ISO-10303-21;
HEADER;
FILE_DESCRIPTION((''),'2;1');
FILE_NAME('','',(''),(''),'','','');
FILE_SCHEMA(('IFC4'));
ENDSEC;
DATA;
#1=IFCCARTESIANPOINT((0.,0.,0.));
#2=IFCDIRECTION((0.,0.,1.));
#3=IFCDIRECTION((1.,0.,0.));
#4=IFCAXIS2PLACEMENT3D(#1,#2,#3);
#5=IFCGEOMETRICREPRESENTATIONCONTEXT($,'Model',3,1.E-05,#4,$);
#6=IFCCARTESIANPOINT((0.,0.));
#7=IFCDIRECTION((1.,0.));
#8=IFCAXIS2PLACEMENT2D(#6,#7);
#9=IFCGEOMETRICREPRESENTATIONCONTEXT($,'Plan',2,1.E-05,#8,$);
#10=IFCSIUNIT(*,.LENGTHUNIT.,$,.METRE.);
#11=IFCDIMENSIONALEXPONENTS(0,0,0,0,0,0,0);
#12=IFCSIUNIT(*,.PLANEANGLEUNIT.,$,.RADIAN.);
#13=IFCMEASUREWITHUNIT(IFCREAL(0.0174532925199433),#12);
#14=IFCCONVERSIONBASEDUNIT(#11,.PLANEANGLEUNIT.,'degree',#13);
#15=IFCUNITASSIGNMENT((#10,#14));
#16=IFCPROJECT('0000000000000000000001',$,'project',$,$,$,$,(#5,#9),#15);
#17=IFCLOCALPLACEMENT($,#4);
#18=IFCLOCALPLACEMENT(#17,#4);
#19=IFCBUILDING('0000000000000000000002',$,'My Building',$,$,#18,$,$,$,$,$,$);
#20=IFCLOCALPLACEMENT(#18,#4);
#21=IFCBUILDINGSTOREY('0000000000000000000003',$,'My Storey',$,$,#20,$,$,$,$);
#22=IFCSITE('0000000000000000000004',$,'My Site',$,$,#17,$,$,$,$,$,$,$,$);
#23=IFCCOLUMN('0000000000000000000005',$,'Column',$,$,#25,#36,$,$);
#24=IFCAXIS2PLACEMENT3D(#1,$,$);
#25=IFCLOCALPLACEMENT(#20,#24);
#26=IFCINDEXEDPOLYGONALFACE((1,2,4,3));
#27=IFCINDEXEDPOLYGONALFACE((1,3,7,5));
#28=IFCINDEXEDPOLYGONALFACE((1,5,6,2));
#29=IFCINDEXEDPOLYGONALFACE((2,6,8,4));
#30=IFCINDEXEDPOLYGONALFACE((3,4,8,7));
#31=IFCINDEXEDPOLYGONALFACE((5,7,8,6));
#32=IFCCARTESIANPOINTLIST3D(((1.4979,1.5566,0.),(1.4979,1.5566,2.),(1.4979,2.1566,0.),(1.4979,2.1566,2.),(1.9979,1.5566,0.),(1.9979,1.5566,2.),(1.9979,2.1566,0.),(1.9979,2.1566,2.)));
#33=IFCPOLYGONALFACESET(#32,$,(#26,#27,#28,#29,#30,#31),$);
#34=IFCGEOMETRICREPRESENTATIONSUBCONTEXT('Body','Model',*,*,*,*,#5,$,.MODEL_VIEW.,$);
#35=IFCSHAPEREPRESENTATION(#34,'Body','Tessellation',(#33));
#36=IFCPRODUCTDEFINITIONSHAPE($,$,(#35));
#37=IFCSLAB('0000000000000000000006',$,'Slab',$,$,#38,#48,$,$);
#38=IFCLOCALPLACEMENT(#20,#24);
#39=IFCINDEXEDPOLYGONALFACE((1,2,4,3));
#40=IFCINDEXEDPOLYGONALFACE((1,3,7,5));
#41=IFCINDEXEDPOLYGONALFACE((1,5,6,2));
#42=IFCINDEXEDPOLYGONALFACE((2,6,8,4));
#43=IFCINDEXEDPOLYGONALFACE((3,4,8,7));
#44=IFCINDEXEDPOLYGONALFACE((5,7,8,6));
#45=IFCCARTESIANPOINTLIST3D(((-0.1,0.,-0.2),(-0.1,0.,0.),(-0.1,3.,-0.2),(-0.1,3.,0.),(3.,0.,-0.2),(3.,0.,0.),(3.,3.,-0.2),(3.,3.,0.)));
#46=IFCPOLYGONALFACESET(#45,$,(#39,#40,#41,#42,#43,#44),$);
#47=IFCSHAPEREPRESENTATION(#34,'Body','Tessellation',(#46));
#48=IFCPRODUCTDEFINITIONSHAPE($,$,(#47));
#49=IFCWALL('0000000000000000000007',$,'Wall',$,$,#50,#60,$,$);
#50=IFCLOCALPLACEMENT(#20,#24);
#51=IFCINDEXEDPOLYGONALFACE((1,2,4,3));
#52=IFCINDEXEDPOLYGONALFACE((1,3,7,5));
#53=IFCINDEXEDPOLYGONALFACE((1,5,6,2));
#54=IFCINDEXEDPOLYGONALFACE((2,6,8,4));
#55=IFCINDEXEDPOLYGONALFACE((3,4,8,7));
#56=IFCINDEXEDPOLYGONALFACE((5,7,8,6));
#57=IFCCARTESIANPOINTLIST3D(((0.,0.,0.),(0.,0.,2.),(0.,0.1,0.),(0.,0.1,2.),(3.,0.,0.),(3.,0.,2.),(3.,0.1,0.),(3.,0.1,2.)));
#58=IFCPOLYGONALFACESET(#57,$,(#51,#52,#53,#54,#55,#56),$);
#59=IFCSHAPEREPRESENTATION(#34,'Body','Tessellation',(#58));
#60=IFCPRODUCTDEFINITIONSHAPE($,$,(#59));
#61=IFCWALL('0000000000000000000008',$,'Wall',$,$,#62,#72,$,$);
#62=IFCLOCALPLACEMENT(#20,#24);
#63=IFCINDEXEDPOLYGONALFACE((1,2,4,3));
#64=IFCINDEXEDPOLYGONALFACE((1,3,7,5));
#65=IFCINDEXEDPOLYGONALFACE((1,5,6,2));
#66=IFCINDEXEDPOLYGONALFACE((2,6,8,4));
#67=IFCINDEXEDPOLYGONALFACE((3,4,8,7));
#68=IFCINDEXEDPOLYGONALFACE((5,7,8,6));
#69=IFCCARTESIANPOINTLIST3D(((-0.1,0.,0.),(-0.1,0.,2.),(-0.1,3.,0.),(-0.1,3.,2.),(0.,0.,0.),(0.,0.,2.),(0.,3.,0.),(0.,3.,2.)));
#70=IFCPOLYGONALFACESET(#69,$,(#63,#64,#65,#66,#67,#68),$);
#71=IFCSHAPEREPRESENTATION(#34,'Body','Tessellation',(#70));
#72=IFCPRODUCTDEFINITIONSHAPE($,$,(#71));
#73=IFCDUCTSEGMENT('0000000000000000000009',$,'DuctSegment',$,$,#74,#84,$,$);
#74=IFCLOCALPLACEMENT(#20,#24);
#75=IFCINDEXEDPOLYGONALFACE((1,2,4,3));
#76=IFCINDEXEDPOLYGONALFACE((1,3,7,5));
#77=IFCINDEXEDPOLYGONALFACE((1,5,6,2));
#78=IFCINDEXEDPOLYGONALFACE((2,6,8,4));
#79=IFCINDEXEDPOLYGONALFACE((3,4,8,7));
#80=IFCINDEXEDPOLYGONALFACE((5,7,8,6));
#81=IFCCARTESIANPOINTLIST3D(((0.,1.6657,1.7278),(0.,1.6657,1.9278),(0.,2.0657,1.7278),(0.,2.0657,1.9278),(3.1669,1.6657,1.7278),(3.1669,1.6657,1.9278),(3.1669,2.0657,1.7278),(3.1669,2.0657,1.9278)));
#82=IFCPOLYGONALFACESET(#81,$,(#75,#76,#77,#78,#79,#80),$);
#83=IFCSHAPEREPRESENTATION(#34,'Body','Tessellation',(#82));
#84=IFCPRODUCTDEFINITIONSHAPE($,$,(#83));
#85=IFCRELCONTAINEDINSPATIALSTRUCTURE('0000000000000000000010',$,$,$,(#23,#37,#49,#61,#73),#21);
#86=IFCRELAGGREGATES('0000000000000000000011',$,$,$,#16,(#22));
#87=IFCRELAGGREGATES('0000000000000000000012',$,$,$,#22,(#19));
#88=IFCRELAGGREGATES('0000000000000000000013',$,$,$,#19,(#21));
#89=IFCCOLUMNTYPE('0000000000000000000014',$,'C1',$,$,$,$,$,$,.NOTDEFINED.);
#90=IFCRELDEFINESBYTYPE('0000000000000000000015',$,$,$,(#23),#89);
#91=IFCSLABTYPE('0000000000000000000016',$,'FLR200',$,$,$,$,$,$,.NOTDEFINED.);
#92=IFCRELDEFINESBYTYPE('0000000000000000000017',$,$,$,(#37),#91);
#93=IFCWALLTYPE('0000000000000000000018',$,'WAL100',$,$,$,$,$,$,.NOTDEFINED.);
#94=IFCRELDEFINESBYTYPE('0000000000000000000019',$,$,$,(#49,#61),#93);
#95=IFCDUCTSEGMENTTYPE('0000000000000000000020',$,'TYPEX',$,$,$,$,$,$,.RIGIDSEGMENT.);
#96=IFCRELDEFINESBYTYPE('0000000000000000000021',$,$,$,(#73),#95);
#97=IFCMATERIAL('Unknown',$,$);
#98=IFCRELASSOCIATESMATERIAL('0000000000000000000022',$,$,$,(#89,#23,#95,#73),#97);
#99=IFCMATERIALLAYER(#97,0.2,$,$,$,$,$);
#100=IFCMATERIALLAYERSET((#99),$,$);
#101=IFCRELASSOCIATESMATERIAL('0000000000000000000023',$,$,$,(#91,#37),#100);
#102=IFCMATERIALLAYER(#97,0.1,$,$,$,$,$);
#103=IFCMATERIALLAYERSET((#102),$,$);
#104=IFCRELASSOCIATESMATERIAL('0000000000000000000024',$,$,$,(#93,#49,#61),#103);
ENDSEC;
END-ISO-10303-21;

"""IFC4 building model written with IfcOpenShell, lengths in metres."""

from ifc_helpers import new_model, entity, si_unit, converted_unit, frame, origin_with_axes, origin_2d_with_axis, place, context, subcontext, project, spatial, line, indexed_curve, rectangle, outline, extrude, material, layer, layer_set, layer_usage, material_profile, profile_set, profile_usage, type_object, element, save


model = new_model("IFC4")

# Units and contexts
model_context = context("Model", 3, precision=1e-05, world=origin_with_axes())
plan_context = context("Plan", 2, precision=1e-05, world=origin_2d_with_axis())
body_context = subcontext(model_context, "Body", "Model", "MODEL_VIEW")
ifc_project = project(units=[si_unit("LENGTHUNIT", "METRE"), converted_unit("PLANEANGLEUNIT", "degree", entity("IfcReal", 0.0174532925199433), si_unit("PLANEANGLEUNIT", "RADIAN"), dimensions=[0, 0, 0, 0, 0, 0, 0])], contexts=[model_context, plan_context])

# Site, building, storey
site_placement = place(None, origin_with_axes())
site = spatial("IfcSite", under=ifc_project, at=site_placement, Name="My Site")
building_placement = place(site_placement, origin_with_axes())
building = spatial("IfcBuilding", under=site, at=building_placement, Name="My Building")
storey_placement = place(building_placement, origin_with_axes())
storey = spatial("IfcBuildingStorey", under=building, at=storey_placement, Name="My Storey")

# Column
ifc_material = material(Name="Unknown")
ifc_material_profile_1 = material_profile(ifc_material, rectangle(XDim=0.5, YDim=0.6))
ifc_profile_set_1 = profile_set([ifc_material_profile_1])
ifc_profile_usage_1 = profile_usage(ifc_profile_set_1, cardinal=5)
column_type = type_object("IfcColumnType", Name="C1", PredefinedType="NOTDEFINED", material=ifc_profile_set_1)
column_placement = place(storey_placement, frame((1.7479, 1.8566, 0.0), z_axis=(0.0, 0.0, 1.0), x_axis=(1.0, 0.0, 0.0)))
element("IfcColumn", 1, at=column_placement, inside=storey, type_object=column_type, material=ifc_profile_usage_1, Name="Column", context=body_context, shape_type="SweptSolid", body=[
    extrude(rectangle(XDim=0.5, YDim=0.6), origin_with_axes(), (0.0, 0.0, 1.0), 2.0),
])

# Slab
ifc_layer_1 = layer(ifc_material, 0.2)
ifc_layer_set_1 = layer_set([ifc_layer_1])
ifc_layer_usage_1 = layer_usage(ifc_layer_set_1, "AXIS3", "POSITIVE", 0.0)
slab_type = type_object("IfcSlabType", Name="FLR200", PredefinedType="NOTDEFINED", material=ifc_layer_set_1)
slab_placement = place(storey_placement, frame((0.0, 0.0, -0.2), z_axis=(0.0, 0.0, 1.0), x_axis=(1.0, 0.0, 0.0)))
element("IfcSlab", 2, at=slab_placement, inside=storey, type_object=slab_type, material=ifc_layer_usage_1, Name="Slab", context=body_context, shape_type="SweptSolid", body=[
    extrude(outline(indexed_curve([(-0.1, 3.0), (-0.1, 0.0), (3.0, 0.0), (3.0, 3.0)], segments=[line(4, 1), line(1, 2), line(2, 3), line(3, 4)], self_intersect=False)), None, (0.0, 0.0, 1.0), 0.2),
])

# Walls
ifc_layer_2 = layer(ifc_material, 0.1)
ifc_layer_set_2 = layer_set([ifc_layer_2])
ifc_layer_usage_2 = layer_usage(ifc_layer_set_2, "AXIS2", "POSITIVE", 0.0)
wall_type = type_object("IfcWallType", Name="WAL100", PredefinedType="NOTDEFINED", material=ifc_layer_set_2)
wall_1_placement = place(storey_placement, frame((0.0, 0.0, 0.0), z_axis=(0.0, 0.0, 1.0), x_axis=(1.0, -0.000001, 0.0)))
element("IfcWall", 3, at=wall_1_placement, inside=storey, type_object=wall_type, material=ifc_layer_usage_2, Name="Wall", context=body_context, shape_type="SweptSolid", body=[
    extrude(outline(indexed_curve([(0.0, 0.0), (0.0, 0.1), (3.0, 0.1), (3.0, 0.0), (0.0, 0.0)], self_intersect=False)), origin_with_axes(), (0.0, 0.0, 1.0), 2.0),
])
ifc_layer_usage_3 = layer_usage(ifc_layer_set_2, "AXIS2", "POSITIVE", 0.0)
wall_2_placement = place(storey_placement, frame((0.0, 0.0, 0.0), z_axis=(0.0, 0.0, 1.0), x_axis=(0.000001, 1.0, 0.0)))
element("IfcWall", 4, at=wall_2_placement, inside=storey, type_object=wall_type, material=ifc_layer_usage_3, Name="Wall", context=body_context, shape_type="SweptSolid", body=[
    extrude(outline(indexed_curve([(0.0, 0.0), (0.0, 0.1), (3.0, 0.1), (3.0, 0.0), (0.0, 0.0)], self_intersect=False)), origin_with_axes(), (0.0, 0.0, 1.0), 2.0),
])

# Duct segment
ifc_material_profile_2 = material_profile(ifc_material, rectangle(XDim=0.4, YDim=0.2))
ifc_profile_set_2 = profile_set([ifc_material_profile_2])
ifc_profile_usage_2 = profile_usage(ifc_profile_set_2, cardinal=5)
duct_segment_type = type_object("IfcDuctSegmentType", Name="TYPEX", PredefinedType="RIGIDSEGMENT", material=ifc_profile_set_2)
duct_segment_placement = place(storey_placement, frame((0.0, 1.8657, 1.8278), z_axis=(1.0, 0.0, 0.0), x_axis=(0.0, 1.0, 0.0)))
element("IfcDuctSegment", 5, at=duct_segment_placement, inside=storey, type_object=duct_segment_type, material=ifc_profile_usage_2, Name="DuctSegment", context=body_context, shape_type="SweptSolid", body=[
    extrude(rectangle(XDim=0.4, YDim=0.2), origin_with_axes(), (0.0, 0.0, 1.0), 3.1669),
])

save(model, "model.ifc")
